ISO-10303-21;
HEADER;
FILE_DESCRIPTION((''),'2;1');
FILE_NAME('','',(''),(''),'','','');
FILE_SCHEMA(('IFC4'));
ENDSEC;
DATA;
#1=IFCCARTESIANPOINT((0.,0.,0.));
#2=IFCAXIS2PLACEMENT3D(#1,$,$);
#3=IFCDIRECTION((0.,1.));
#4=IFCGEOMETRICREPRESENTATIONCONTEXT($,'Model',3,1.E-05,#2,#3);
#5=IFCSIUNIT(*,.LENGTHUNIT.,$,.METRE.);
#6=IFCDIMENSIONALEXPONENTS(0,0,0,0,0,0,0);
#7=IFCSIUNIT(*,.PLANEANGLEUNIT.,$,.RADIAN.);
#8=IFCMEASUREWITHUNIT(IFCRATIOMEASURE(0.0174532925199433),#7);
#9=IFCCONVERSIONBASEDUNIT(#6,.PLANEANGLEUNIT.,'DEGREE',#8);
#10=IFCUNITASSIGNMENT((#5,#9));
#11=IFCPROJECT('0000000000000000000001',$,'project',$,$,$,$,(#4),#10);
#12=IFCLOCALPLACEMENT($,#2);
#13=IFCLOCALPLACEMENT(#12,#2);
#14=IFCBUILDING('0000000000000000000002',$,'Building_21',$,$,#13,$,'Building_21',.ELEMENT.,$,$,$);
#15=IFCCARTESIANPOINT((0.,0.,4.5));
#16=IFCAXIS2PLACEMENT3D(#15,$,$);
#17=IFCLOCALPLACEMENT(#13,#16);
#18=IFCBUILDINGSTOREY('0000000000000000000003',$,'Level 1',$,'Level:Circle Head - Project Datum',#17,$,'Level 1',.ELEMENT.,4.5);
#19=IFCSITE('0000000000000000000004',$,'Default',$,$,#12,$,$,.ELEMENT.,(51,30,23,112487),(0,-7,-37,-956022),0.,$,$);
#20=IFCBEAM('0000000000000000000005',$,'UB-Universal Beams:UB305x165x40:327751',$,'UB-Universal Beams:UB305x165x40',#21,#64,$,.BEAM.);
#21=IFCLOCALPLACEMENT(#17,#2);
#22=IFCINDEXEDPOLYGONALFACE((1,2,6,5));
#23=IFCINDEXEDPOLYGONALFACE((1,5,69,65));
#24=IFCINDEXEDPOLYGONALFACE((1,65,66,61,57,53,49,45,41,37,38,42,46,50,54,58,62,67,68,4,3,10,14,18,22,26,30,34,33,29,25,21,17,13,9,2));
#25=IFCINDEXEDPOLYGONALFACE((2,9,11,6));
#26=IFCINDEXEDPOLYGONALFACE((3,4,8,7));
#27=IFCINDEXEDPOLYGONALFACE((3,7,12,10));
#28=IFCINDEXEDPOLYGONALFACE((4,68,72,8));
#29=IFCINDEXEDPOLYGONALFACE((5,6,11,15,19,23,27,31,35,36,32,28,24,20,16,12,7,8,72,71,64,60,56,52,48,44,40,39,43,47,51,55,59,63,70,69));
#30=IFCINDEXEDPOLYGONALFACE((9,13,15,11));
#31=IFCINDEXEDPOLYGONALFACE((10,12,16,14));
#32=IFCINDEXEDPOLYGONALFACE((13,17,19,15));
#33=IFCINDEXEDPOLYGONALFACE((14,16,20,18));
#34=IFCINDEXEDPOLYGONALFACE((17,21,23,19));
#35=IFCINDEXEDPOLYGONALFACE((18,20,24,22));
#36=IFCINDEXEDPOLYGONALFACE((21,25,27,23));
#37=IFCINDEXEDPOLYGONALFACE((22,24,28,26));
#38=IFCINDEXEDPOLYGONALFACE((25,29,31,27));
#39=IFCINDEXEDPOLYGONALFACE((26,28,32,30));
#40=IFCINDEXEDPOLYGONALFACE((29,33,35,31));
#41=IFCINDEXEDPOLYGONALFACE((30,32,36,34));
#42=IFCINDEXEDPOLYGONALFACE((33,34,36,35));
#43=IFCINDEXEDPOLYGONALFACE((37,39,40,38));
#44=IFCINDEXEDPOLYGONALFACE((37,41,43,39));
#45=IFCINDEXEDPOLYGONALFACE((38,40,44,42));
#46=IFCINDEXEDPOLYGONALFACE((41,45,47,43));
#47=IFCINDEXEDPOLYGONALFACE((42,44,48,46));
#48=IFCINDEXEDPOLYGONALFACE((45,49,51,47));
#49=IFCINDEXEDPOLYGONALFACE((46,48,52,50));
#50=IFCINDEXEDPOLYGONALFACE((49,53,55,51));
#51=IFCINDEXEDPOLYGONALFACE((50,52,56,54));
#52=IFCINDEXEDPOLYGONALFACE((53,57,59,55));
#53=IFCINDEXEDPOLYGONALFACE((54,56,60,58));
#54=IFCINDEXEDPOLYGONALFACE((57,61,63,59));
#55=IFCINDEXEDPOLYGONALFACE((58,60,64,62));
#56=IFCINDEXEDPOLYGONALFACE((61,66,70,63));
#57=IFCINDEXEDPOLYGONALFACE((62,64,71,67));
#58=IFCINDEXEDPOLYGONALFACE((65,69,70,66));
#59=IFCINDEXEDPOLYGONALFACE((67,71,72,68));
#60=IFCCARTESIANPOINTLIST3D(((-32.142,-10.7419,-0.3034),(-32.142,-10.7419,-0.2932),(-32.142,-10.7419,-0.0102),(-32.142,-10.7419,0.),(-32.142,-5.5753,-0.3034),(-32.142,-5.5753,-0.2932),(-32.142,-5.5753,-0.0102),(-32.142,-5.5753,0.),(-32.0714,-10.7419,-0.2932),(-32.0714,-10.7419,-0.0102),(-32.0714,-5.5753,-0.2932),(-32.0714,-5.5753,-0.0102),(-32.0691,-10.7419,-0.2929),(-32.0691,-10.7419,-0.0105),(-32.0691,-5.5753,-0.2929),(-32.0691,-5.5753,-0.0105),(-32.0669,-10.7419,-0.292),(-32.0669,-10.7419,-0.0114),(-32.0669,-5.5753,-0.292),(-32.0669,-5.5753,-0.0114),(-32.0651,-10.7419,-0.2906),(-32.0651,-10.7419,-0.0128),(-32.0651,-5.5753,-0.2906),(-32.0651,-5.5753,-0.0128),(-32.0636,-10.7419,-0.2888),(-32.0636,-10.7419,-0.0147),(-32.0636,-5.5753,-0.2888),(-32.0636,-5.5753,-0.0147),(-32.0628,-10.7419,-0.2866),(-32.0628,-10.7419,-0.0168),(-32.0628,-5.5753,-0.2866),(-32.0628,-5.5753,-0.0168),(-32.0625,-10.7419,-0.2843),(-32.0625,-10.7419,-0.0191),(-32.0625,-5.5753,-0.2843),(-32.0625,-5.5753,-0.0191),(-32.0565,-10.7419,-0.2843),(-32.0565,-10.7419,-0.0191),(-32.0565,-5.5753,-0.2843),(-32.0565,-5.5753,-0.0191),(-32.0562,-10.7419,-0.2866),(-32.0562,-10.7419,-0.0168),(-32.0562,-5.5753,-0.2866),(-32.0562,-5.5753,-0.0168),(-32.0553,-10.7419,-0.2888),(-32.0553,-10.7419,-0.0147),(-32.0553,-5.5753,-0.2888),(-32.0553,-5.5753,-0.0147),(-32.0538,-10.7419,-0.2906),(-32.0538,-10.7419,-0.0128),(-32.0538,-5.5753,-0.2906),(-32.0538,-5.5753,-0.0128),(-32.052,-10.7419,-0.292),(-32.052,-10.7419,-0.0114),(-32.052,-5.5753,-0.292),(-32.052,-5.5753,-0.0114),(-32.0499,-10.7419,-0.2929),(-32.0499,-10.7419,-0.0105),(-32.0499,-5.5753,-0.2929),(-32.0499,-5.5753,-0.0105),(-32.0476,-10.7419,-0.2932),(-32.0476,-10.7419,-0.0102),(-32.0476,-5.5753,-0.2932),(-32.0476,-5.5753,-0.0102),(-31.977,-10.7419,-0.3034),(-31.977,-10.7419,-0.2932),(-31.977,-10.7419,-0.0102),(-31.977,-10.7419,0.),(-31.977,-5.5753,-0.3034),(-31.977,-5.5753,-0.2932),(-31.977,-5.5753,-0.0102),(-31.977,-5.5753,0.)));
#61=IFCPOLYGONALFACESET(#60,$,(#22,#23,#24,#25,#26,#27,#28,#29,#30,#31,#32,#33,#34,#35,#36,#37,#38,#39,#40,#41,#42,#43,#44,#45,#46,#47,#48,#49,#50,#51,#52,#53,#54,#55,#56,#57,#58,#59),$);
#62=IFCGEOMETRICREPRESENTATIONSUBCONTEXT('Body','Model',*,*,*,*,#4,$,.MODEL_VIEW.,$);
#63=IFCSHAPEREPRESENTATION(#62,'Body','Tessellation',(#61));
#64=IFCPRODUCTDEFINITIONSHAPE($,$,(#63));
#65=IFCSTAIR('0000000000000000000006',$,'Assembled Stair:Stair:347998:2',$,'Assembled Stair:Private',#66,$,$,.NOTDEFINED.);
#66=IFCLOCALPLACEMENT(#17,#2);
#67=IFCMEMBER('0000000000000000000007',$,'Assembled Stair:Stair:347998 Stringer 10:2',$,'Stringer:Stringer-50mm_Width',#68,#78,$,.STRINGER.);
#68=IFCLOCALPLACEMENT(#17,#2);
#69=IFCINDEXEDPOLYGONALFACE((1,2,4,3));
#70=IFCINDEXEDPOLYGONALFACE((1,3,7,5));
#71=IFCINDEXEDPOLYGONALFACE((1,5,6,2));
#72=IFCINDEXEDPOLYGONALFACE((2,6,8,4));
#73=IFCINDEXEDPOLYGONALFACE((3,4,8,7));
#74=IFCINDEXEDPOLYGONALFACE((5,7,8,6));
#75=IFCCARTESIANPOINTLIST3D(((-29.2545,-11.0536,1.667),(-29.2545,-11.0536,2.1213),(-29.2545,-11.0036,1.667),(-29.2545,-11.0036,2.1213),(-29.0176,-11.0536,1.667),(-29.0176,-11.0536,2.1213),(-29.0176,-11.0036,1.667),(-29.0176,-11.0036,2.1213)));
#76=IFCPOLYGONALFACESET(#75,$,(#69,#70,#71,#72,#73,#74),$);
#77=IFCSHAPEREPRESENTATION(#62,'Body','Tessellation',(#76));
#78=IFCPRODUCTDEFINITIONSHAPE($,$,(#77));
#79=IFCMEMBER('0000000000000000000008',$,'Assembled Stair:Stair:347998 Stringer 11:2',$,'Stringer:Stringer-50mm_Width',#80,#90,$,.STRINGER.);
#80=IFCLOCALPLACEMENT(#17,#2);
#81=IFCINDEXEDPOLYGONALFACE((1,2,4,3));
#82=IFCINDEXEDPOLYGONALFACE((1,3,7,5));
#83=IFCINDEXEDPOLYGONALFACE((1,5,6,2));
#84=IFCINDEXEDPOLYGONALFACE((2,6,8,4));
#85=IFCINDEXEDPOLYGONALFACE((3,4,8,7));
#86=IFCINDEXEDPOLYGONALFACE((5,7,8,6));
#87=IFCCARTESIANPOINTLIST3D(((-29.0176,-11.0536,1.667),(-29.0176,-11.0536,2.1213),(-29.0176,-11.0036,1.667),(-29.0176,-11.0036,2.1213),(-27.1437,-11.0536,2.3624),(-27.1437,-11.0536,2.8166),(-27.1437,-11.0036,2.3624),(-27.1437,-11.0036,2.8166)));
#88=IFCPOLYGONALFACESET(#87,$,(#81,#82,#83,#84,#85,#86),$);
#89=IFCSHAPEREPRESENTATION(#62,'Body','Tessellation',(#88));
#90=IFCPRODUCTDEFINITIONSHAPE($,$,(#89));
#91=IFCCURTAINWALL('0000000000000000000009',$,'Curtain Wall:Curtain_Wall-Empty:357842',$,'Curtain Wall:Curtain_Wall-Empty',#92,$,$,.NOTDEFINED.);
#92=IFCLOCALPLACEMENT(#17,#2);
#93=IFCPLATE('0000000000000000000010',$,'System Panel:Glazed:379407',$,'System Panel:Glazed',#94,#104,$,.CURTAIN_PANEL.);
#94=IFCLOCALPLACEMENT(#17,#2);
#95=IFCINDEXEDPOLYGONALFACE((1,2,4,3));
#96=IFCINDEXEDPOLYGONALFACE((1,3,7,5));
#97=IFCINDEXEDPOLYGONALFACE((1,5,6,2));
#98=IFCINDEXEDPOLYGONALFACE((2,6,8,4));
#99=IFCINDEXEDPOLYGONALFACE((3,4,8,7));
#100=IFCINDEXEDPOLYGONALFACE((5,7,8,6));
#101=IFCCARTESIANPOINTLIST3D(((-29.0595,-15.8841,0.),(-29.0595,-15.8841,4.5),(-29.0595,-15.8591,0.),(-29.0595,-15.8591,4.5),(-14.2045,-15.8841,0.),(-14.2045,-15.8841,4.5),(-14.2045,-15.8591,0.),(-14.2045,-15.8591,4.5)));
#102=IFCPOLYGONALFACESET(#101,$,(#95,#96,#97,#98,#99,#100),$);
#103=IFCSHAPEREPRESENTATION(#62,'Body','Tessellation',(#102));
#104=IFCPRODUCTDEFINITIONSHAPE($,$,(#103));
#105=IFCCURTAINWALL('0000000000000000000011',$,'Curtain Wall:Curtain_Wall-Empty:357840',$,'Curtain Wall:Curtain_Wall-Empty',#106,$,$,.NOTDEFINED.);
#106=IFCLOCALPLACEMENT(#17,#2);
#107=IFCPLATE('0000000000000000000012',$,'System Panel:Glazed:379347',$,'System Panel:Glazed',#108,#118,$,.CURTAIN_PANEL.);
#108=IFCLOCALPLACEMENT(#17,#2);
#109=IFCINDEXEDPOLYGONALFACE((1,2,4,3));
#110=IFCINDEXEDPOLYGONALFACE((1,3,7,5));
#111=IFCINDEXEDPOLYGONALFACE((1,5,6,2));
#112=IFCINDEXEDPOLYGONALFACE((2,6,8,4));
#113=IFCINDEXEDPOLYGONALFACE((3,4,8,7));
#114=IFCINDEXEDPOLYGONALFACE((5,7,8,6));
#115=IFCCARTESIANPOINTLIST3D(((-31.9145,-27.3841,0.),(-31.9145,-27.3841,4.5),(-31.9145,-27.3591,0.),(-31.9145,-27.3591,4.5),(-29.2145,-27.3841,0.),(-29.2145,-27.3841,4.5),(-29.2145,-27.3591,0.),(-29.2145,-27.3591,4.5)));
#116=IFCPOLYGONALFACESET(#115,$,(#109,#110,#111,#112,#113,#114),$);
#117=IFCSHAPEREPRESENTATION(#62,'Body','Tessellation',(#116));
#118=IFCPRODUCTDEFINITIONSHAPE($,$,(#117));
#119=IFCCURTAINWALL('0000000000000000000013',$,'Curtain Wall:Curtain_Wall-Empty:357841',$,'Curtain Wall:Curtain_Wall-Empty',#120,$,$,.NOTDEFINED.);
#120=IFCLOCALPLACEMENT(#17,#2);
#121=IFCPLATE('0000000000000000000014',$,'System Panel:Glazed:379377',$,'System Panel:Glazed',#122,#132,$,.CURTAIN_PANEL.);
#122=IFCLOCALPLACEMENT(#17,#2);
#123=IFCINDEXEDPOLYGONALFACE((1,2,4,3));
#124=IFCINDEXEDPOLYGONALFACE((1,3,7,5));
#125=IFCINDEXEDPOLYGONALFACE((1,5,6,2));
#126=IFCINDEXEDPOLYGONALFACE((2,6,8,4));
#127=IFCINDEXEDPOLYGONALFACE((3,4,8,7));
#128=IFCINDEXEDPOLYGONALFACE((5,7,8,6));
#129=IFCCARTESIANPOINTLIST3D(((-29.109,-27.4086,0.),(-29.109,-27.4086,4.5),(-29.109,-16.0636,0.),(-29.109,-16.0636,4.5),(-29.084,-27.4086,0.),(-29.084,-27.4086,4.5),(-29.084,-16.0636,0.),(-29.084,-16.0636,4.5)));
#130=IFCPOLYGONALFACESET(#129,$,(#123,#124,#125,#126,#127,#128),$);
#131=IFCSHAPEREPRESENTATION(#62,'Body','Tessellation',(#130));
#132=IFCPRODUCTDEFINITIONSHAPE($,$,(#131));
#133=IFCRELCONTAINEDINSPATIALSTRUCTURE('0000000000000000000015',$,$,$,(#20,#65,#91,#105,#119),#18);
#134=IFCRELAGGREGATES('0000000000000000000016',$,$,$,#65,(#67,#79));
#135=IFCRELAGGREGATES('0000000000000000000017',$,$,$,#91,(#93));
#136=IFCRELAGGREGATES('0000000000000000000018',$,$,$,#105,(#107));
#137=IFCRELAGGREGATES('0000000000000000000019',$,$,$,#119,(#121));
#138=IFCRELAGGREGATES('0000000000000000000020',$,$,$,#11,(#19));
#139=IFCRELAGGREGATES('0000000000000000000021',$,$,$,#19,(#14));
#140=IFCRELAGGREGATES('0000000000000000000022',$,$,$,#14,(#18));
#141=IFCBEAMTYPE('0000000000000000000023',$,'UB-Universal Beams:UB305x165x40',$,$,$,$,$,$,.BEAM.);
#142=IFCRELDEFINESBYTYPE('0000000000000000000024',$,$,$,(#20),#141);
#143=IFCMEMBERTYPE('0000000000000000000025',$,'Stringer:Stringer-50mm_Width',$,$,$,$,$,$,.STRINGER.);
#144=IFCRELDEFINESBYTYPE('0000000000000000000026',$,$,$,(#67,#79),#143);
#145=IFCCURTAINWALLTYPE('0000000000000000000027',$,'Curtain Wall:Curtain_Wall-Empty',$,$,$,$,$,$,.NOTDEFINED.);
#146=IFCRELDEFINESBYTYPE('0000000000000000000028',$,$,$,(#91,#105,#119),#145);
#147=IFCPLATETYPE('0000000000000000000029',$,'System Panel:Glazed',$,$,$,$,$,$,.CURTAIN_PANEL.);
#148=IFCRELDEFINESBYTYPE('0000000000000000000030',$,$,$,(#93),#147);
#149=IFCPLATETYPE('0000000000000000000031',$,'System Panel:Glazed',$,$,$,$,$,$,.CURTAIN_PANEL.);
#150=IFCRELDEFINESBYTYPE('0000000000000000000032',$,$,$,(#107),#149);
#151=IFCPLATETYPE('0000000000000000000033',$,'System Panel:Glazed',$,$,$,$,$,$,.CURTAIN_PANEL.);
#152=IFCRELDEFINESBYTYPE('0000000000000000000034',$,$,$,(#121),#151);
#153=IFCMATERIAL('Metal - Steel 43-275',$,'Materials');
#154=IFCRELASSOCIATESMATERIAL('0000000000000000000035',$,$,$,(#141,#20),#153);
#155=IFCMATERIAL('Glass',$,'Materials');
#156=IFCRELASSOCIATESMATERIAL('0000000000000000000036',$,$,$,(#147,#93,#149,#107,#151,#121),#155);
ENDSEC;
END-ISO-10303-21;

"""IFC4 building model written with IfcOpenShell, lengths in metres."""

from ifc_helpers import new_model, entity, si_unit, converted_unit, direction, frame, frame_2d, origin, origin_2d_with_axis, place, context, subcontext, project, spatial, polyline, circle_curve, parameter, trimmed, segment, composite_curve, rectangle, i_section, outline, extrude, source, transform, mapped, material, material_profile, profile_set, profile_usage, type_object, type_shapes, element, aggregate, save


model = new_model("IFC4")

# Units and contexts
model_context = context("Model", 3, precision=1e-05, world=origin(), true_north=direction((0.0, 1.0)))
body_context = subcontext(model_context, "Body", "Model", "MODEL_VIEW")
ifc_project = project(units=[si_unit("LENGTHUNIT", "METRE"), converted_unit("PLANEANGLEUNIT", "DEGREE", entity("IfcRatioMeasure", 0.0174532925199433), si_unit("PLANEANGLEUNIT", "RADIAN"), dimensions=[0, 0, 0, 0, 0, 0, 0])], contexts=[model_context])

# Site, building, storey
site_placement = place(None, origin())
site = spatial("IfcSite", under=ifc_project, at=site_placement, Name="Default", CompositionType="ELEMENT", RefLatitude=(51, 30, 23, 112487), RefLongitude=(0, -7, -37, -956022), RefElevation=0.0)
building_placement = place(site_placement, origin())
building = spatial("IfcBuilding", under=site, at=building_placement, Name="Building_21", LongName="Building_21", CompositionType="ELEMENT")
storey_placement = place(building_placement, frame((0.0, 0.0, 4.5)))
storey = spatial("IfcBuildingStorey", under=building, at=storey_placement, Name="Level 1", ObjectType="Level:Circle Head - Project Datum", LongName="Level 1", CompositionType="ELEMENT", Elevation=4.5)

# Shared definitions
ifc_material_1 = material(Name="Metal - Steel 43-275", Category="Materials")

# Beam
ifc_material_profile_1 = material_profile(ifc_material_1, outline(composite_curve([segment(polyline([(0.0119, -0.1415, 0.0), (0.0825, -0.1415, 0.0)]), True, "CONTINUOUS"), segment(polyline([(0.0825, -0.1415, 0.0), (0.0825, -0.1517, 0.0)]), True, "CONTINUOUS"), segment(polyline([(0.0825, -0.1517, 0.0), (-0.0825, -0.1517, 0.0)]), True, "CONTINUOUS"), segment(polyline([(-0.0825, -0.1517, 0.0), (-0.0825, -0.1415, 0.0)]), True, "CONTINUOUS"), segment(polyline([(-0.0825, -0.1415, 0.0), (-0.0119, -0.1415, 0.0)]), True, "CONTINUOUS"), segment(trimmed(circle_curve(frame((-0.0119, -0.1326, 0.0), z_axis=(0.0, 0.0, 1.0), x_axis=(-1.0, 0.0, 0.0)), 0.0089), [parameter(90.0)], [parameter(180.0)], True, "PARAMETER"), True, "CONTINUOUS"), segment(polyline([(-0.003, -0.1326, 0.0), (-0.003, 0.1326, 0.0)]), True, "CONTINUOUS"), segment(trimmed(circle_curve(frame((-0.0119, 0.1326, 0.0), z_axis=(0.0, 0.0, 1.0), x_axis=(-1.0, 0.0, 0.0)), 0.0089), [parameter(180.0)], [parameter(270.0)], True, "PARAMETER"), True, "CONTINUOUS"), segment(polyline([(-0.0119, 0.1415, 0.0), (-0.0825, 0.1415, 0.0)]), True, "CONTINUOUS"), segment(polyline([(-0.0825, 0.1415, 0.0), (-0.0825, 0.1517, 0.0)]), True, "CONTINUOUS"), segment(polyline([(-0.0825, 0.1517, 0.0), (0.0825, 0.1517, 0.0)]), True, "CONTINUOUS"), segment(polyline([(0.0825, 0.1517, 0.0), (0.0825, 0.1415, 0.0)]), True, "CONTINUOUS"), segment(polyline([(0.0825, 0.1415, 0.0), (0.0119, 0.1415, 0.0)]), True, "CONTINUOUS"), segment(trimmed(circle_curve(frame((0.0119, 0.1326, 0.0), z_axis=(0.0, 0.0, 1.0), x_axis=(-1.0, 0.0, 0.0)), 0.0089), [parameter(270.0)], [parameter(0.0)], True, "PARAMETER"), True, "CONTINUOUS"), segment(polyline([(0.003, 0.1326, 0.0), (0.003, -0.1326, 0.0)]), True, "CONTINUOUS"), segment(trimmed(circle_curve(frame((0.0119, -0.1326, 0.0), z_axis=(0.0, 0.0, 1.0), x_axis=(-1.0, 0.0, 0.0)), 0.0089), [parameter(0.0)], [parameter(90.0)], True, "PARAMETER"), True, "CONTINUOUS")], self_intersect=False), kind="CURVE"), Name="UB305x165x40")
ifc_material_profile_2 = material_profile(ifc_material_1, outline(composite_curve([segment(polyline([(-1.3346, 0.0825, -0.1415), (-1.3346, 0.0825, -0.1517)]), True, "CONTINUOUS"), segment(polyline([(-1.3346, 0.0825, -0.1517), (-1.3346, -0.0825, -0.1517)]), True, "CONTINUOUS"), segment(polyline([(-1.3346, -0.0825, -0.1517), (-1.3346, -0.0825, -0.1415)]), True, "CONTINUOUS"), segment(polyline([(-1.3346, -0.0825, -0.1415), (-1.3346, -0.003, -0.1415)]), True, "CONTINUOUS"), segment(polyline([(-1.3346, -0.003, -0.1415), (-1.3346, -0.003, 0.1415)]), True, "CONTINUOUS"), segment(polyline([(-1.3346, -0.003, 0.1415), (-1.3346, -0.0825, 0.1415)]), True, "CONTINUOUS"), segment(polyline([(-1.3346, -0.0825, 0.1415), (-1.3346, -0.0825, 0.1517)]), True, "CONTINUOUS"), segment(polyline([(-1.3346, -0.0825, 0.1517), (-1.3346, 0.0825, 0.1517)]), True, "CONTINUOUS"), segment(polyline([(-1.3346, 0.0825, 0.1517), (-1.3346, 0.0825, 0.1415)]), True, "CONTINUOUS"), segment(polyline([(-1.3346, 0.0825, 0.1415), (-1.3346, 0.003, 0.1415)]), True, "CONTINUOUS"), segment(polyline([(-1.3346, 0.003, 0.1415), (-1.3346, 0.003, -0.1415)]), True, "CONTINUOUS"), segment(polyline([(-1.3346, 0.003, -0.1415), (-1.3346, 0.0825, -0.1415)]), True, "CONTINUOUS")], self_intersect=False), kind="CURVE"), Name="UB305x165x40")
ifc_profile_set_1 = profile_set([ifc_material_profile_1, ifc_material_profile_2], Name="UB305x165x40")
beam_type_1 = type_object("IfcBeamType", Name="UB-Universal Beams:UB305x165x40", PredefinedType="BEAM", material=ifc_profile_set_1)
shared_shape_1 = source(origin(), body_context, "Body", "SweptSolid", [
    extrude(i_section(OverallWidth=0.165, OverallDepth=0.3034, WebThickness=0.006, FlangeThickness=0.0102, FilletRadius=0.0089, at=frame_2d((0.0, 0.0), x_axis=(0.0, 1.0))), frame((-2.5833, 0.0, 0.0), z_axis=(1.0, 0.0, 0.0), x_axis=(0.0, 0.0, -1.0)), (0.0, 0.0, 1.0), 5.1666),
])
type_shapes(beam_type_1, [shared_shape_1])
ifc_profile_usage_1 = profile_usage(ifc_profile_set_1, cardinal=8)
beam_1_placement = place(storey_placement, frame((-32.0595, -8.1586, -0.1517), z_axis=(0.0, 0.0, 1.0), x_axis=(0.0, -1.0, 0.0)))
element("IfcBeam", 1, at=beam_1_placement, inside=storey, type_object=beam_type_1, material=ifc_profile_usage_1, Name="UB-Universal Beams:UB305x165x40:327751", ObjectType="UB-Universal Beams:UB305x165x40", PredefinedType="BEAM", context=body_context, shape_type="MappedRepresentation", body=[
    mapped(shared_shape_1, transform((0.0, 0.0, 0.0), scale=1.0)),
])

# Stair, members
stair_placement = place(storey_placement, origin())
stair = element("IfcStair", 2, at=stair_placement, inside=storey, Name="Assembled Stair:Stair:347998:2", ObjectType="Assembled Stair:Private", PredefinedType="NOTDEFINED")
member_type = type_object("IfcMemberType", Name="Stringer:Stringer-50mm_Width", PredefinedType="STRINGER")
member_1_placement = place(stair_placement, frame((-29.2545, -11.0536, 1.667)))
member_1 = element("IfcMember", 3, at=member_1_placement, type_object=member_type, Name="Assembled Stair:Stair:347998 Stringer 10:2", ObjectType="Stringer:Stringer-50mm_Width", PredefinedType="STRINGER", context=body_context, shape_type="SweptSolid", body=[
    extrude(rectangle(XDim=0.2368, YDim=0.05, at=frame_2d((0.0, 0.0), x_axis=(1.0, 0.0))), frame((0.1184, 0.025, 0.0)), (0.0, 0.0, 1.0), 0.4543),
])
member_2_placement = place(stair_placement, frame((-29.0176, -11.0536, 1.667)))
member_2 = element("IfcMember", 4, at=member_2_placement, type_object=member_type, Name="Assembled Stair:Stair:347998 Stringer 11:2", ObjectType="Stringer:Stringer-50mm_Width", PredefinedType="STRINGER", context=body_context, shape_type="SweptSolid", body=[
    extrude(outline(polyline([(-0.9204, -0.213), (1.0784, -0.213), (0.9204, 0.213), (-1.0784, 0.213), (-0.9204, -0.213)])), frame((0.937, 0.0, 0.5748), z_axis=(0.0, 1.0, 0.0), x_axis=(0.937533, 0.0, 0.347896)), (0.0, 0.0, 1.0), 0.05),
])
aggregate(stair, [member_1, member_2])

# Curtain walls, plates
curtain_wall_type = type_object("IfcCurtainWallType", Name="Curtain Wall:Curtain_Wall-Empty", PredefinedType="NOTDEFINED")
curtain_wall_1_placement = place(storey_placement, frame((0.0, 0.0, -4.5)))
curtain_wall_1 = element("IfcCurtainWall", 5, at=curtain_wall_1_placement, inside=storey, type_object=curtain_wall_type, Name="Curtain Wall:Curtain_Wall-Empty:357842", ObjectType="Curtain Wall:Curtain_Wall-Empty", PredefinedType="NOTDEFINED")
ifc_material_2 = material(Name="Glass", Category="Materials")
plate_type_1 = type_object("IfcPlateType", Name="System Panel:Glazed", PredefinedType="CURTAIN_PANEL", material=ifc_material_2)
shared_shape_2 = source(origin(), body_context, "Body", "SweptSolid", [
    extrude(rectangle(XDim=0.025, YDim=14.855, at=origin_2d_with_axis()), frame((7.4275, 0.0125, 0.0), z_axis=(0.0, 0.0, 1.0), x_axis=(0.0, 1.0, 0.0)), (0.0, 0.0, 1.0), 4.5),
])
type_shapes(plate_type_1, [shared_shape_2])
plate_1_placement = place(curtain_wall_1_placement, frame((-29.0595, -15.8841, 4.5)))
plate_1 = element("IfcPlate", 6, at=plate_1_placement, type_object=plate_type_1, material=ifc_material_2, Name="System Panel:Glazed:379407", ObjectType="System Panel:Glazed", PredefinedType="CURTAIN_PANEL", context=body_context, shape_type="MappedRepresentation", body=[
    mapped(shared_shape_2, transform((0.0, 0.0, 0.0), scale=1.0)),
])
aggregate(curtain_wall_1, [plate_1])
curtain_wall_2_placement = place(storey_placement, frame((0.0, 0.0, -4.5)))
curtain_wall_2 = element("IfcCurtainWall", 7, at=curtain_wall_2_placement, inside=storey, type_object=curtain_wall_type, Name="Curtain Wall:Curtain_Wall-Empty:357840", ObjectType="Curtain Wall:Curtain_Wall-Empty", PredefinedType="NOTDEFINED")
plate_type_2 = type_object("IfcPlateType", Name="System Panel:Glazed", PredefinedType="CURTAIN_PANEL", material=ifc_material_2)
shared_shape_3 = source(origin(), body_context, "Body", "SweptSolid", [
    extrude(rectangle(XDim=0.025, YDim=2.7, at=origin_2d_with_axis()), frame((1.35, 0.0125, 0.0), z_axis=(0.0, 0.0, 1.0), x_axis=(0.0, 1.0, 0.0)), (0.0, 0.0, 1.0), 4.5),
])
type_shapes(plate_type_2, [shared_shape_3])
plate_2_placement = place(curtain_wall_2_placement, frame((-31.9145, -27.3841, 4.5)))
plate_2 = element("IfcPlate", 8, at=plate_2_placement, type_object=plate_type_2, material=ifc_material_2, Name="System Panel:Glazed:379347", ObjectType="System Panel:Glazed", PredefinedType="CURTAIN_PANEL", context=body_context, shape_type="MappedRepresentation", body=[
    mapped(shared_shape_3, transform((0.0, 0.0, 0.0), scale=1.0)),
])
aggregate(curtain_wall_2, [plate_2])
curtain_wall_3_placement = place(storey_placement, frame((0.0, 0.0, -4.5)))
curtain_wall_3 = element("IfcCurtainWall", 9, at=curtain_wall_3_placement, inside=storey, type_object=curtain_wall_type, Name="Curtain Wall:Curtain_Wall-Empty:357841", ObjectType="Curtain Wall:Curtain_Wall-Empty", PredefinedType="NOTDEFINED")
plate_type_3 = type_object("IfcPlateType", Name="System Panel:Glazed", PredefinedType="CURTAIN_PANEL", material=ifc_material_2)
shared_shape_4 = source(origin(), body_context, "Body", "SweptSolid", [
    extrude(rectangle(XDim=0.025, YDim=11.345, at=origin_2d_with_axis()), frame((5.6725, 0.0125, 0.0), z_axis=(0.0, 0.0, 1.0), x_axis=(0.0, 1.0, 0.0)), (0.0, 0.0, 1.0), 4.5),
])
type_shapes(plate_type_3, [shared_shape_4])
plate_3_placement = place(curtain_wall_3_placement, frame((-29.084, -27.4086, 4.5), z_axis=(0.0, 0.0, 1.0), x_axis=(0.0, 1.0, 0.0)))
plate_3 = element("IfcPlate", 10, at=plate_3_placement, type_object=plate_type_3, material=ifc_material_2, Name="System Panel:Glazed:379377", ObjectType="System Panel:Glazed", PredefinedType="CURTAIN_PANEL", context=body_context, shape_type="MappedRepresentation", body=[
    mapped(shared_shape_4, transform((0.0, 0.0, 0.0), scale=1.0)),
])
aggregate(curtain_wall_3, [plate_3])

save(model, "model.ifc")
